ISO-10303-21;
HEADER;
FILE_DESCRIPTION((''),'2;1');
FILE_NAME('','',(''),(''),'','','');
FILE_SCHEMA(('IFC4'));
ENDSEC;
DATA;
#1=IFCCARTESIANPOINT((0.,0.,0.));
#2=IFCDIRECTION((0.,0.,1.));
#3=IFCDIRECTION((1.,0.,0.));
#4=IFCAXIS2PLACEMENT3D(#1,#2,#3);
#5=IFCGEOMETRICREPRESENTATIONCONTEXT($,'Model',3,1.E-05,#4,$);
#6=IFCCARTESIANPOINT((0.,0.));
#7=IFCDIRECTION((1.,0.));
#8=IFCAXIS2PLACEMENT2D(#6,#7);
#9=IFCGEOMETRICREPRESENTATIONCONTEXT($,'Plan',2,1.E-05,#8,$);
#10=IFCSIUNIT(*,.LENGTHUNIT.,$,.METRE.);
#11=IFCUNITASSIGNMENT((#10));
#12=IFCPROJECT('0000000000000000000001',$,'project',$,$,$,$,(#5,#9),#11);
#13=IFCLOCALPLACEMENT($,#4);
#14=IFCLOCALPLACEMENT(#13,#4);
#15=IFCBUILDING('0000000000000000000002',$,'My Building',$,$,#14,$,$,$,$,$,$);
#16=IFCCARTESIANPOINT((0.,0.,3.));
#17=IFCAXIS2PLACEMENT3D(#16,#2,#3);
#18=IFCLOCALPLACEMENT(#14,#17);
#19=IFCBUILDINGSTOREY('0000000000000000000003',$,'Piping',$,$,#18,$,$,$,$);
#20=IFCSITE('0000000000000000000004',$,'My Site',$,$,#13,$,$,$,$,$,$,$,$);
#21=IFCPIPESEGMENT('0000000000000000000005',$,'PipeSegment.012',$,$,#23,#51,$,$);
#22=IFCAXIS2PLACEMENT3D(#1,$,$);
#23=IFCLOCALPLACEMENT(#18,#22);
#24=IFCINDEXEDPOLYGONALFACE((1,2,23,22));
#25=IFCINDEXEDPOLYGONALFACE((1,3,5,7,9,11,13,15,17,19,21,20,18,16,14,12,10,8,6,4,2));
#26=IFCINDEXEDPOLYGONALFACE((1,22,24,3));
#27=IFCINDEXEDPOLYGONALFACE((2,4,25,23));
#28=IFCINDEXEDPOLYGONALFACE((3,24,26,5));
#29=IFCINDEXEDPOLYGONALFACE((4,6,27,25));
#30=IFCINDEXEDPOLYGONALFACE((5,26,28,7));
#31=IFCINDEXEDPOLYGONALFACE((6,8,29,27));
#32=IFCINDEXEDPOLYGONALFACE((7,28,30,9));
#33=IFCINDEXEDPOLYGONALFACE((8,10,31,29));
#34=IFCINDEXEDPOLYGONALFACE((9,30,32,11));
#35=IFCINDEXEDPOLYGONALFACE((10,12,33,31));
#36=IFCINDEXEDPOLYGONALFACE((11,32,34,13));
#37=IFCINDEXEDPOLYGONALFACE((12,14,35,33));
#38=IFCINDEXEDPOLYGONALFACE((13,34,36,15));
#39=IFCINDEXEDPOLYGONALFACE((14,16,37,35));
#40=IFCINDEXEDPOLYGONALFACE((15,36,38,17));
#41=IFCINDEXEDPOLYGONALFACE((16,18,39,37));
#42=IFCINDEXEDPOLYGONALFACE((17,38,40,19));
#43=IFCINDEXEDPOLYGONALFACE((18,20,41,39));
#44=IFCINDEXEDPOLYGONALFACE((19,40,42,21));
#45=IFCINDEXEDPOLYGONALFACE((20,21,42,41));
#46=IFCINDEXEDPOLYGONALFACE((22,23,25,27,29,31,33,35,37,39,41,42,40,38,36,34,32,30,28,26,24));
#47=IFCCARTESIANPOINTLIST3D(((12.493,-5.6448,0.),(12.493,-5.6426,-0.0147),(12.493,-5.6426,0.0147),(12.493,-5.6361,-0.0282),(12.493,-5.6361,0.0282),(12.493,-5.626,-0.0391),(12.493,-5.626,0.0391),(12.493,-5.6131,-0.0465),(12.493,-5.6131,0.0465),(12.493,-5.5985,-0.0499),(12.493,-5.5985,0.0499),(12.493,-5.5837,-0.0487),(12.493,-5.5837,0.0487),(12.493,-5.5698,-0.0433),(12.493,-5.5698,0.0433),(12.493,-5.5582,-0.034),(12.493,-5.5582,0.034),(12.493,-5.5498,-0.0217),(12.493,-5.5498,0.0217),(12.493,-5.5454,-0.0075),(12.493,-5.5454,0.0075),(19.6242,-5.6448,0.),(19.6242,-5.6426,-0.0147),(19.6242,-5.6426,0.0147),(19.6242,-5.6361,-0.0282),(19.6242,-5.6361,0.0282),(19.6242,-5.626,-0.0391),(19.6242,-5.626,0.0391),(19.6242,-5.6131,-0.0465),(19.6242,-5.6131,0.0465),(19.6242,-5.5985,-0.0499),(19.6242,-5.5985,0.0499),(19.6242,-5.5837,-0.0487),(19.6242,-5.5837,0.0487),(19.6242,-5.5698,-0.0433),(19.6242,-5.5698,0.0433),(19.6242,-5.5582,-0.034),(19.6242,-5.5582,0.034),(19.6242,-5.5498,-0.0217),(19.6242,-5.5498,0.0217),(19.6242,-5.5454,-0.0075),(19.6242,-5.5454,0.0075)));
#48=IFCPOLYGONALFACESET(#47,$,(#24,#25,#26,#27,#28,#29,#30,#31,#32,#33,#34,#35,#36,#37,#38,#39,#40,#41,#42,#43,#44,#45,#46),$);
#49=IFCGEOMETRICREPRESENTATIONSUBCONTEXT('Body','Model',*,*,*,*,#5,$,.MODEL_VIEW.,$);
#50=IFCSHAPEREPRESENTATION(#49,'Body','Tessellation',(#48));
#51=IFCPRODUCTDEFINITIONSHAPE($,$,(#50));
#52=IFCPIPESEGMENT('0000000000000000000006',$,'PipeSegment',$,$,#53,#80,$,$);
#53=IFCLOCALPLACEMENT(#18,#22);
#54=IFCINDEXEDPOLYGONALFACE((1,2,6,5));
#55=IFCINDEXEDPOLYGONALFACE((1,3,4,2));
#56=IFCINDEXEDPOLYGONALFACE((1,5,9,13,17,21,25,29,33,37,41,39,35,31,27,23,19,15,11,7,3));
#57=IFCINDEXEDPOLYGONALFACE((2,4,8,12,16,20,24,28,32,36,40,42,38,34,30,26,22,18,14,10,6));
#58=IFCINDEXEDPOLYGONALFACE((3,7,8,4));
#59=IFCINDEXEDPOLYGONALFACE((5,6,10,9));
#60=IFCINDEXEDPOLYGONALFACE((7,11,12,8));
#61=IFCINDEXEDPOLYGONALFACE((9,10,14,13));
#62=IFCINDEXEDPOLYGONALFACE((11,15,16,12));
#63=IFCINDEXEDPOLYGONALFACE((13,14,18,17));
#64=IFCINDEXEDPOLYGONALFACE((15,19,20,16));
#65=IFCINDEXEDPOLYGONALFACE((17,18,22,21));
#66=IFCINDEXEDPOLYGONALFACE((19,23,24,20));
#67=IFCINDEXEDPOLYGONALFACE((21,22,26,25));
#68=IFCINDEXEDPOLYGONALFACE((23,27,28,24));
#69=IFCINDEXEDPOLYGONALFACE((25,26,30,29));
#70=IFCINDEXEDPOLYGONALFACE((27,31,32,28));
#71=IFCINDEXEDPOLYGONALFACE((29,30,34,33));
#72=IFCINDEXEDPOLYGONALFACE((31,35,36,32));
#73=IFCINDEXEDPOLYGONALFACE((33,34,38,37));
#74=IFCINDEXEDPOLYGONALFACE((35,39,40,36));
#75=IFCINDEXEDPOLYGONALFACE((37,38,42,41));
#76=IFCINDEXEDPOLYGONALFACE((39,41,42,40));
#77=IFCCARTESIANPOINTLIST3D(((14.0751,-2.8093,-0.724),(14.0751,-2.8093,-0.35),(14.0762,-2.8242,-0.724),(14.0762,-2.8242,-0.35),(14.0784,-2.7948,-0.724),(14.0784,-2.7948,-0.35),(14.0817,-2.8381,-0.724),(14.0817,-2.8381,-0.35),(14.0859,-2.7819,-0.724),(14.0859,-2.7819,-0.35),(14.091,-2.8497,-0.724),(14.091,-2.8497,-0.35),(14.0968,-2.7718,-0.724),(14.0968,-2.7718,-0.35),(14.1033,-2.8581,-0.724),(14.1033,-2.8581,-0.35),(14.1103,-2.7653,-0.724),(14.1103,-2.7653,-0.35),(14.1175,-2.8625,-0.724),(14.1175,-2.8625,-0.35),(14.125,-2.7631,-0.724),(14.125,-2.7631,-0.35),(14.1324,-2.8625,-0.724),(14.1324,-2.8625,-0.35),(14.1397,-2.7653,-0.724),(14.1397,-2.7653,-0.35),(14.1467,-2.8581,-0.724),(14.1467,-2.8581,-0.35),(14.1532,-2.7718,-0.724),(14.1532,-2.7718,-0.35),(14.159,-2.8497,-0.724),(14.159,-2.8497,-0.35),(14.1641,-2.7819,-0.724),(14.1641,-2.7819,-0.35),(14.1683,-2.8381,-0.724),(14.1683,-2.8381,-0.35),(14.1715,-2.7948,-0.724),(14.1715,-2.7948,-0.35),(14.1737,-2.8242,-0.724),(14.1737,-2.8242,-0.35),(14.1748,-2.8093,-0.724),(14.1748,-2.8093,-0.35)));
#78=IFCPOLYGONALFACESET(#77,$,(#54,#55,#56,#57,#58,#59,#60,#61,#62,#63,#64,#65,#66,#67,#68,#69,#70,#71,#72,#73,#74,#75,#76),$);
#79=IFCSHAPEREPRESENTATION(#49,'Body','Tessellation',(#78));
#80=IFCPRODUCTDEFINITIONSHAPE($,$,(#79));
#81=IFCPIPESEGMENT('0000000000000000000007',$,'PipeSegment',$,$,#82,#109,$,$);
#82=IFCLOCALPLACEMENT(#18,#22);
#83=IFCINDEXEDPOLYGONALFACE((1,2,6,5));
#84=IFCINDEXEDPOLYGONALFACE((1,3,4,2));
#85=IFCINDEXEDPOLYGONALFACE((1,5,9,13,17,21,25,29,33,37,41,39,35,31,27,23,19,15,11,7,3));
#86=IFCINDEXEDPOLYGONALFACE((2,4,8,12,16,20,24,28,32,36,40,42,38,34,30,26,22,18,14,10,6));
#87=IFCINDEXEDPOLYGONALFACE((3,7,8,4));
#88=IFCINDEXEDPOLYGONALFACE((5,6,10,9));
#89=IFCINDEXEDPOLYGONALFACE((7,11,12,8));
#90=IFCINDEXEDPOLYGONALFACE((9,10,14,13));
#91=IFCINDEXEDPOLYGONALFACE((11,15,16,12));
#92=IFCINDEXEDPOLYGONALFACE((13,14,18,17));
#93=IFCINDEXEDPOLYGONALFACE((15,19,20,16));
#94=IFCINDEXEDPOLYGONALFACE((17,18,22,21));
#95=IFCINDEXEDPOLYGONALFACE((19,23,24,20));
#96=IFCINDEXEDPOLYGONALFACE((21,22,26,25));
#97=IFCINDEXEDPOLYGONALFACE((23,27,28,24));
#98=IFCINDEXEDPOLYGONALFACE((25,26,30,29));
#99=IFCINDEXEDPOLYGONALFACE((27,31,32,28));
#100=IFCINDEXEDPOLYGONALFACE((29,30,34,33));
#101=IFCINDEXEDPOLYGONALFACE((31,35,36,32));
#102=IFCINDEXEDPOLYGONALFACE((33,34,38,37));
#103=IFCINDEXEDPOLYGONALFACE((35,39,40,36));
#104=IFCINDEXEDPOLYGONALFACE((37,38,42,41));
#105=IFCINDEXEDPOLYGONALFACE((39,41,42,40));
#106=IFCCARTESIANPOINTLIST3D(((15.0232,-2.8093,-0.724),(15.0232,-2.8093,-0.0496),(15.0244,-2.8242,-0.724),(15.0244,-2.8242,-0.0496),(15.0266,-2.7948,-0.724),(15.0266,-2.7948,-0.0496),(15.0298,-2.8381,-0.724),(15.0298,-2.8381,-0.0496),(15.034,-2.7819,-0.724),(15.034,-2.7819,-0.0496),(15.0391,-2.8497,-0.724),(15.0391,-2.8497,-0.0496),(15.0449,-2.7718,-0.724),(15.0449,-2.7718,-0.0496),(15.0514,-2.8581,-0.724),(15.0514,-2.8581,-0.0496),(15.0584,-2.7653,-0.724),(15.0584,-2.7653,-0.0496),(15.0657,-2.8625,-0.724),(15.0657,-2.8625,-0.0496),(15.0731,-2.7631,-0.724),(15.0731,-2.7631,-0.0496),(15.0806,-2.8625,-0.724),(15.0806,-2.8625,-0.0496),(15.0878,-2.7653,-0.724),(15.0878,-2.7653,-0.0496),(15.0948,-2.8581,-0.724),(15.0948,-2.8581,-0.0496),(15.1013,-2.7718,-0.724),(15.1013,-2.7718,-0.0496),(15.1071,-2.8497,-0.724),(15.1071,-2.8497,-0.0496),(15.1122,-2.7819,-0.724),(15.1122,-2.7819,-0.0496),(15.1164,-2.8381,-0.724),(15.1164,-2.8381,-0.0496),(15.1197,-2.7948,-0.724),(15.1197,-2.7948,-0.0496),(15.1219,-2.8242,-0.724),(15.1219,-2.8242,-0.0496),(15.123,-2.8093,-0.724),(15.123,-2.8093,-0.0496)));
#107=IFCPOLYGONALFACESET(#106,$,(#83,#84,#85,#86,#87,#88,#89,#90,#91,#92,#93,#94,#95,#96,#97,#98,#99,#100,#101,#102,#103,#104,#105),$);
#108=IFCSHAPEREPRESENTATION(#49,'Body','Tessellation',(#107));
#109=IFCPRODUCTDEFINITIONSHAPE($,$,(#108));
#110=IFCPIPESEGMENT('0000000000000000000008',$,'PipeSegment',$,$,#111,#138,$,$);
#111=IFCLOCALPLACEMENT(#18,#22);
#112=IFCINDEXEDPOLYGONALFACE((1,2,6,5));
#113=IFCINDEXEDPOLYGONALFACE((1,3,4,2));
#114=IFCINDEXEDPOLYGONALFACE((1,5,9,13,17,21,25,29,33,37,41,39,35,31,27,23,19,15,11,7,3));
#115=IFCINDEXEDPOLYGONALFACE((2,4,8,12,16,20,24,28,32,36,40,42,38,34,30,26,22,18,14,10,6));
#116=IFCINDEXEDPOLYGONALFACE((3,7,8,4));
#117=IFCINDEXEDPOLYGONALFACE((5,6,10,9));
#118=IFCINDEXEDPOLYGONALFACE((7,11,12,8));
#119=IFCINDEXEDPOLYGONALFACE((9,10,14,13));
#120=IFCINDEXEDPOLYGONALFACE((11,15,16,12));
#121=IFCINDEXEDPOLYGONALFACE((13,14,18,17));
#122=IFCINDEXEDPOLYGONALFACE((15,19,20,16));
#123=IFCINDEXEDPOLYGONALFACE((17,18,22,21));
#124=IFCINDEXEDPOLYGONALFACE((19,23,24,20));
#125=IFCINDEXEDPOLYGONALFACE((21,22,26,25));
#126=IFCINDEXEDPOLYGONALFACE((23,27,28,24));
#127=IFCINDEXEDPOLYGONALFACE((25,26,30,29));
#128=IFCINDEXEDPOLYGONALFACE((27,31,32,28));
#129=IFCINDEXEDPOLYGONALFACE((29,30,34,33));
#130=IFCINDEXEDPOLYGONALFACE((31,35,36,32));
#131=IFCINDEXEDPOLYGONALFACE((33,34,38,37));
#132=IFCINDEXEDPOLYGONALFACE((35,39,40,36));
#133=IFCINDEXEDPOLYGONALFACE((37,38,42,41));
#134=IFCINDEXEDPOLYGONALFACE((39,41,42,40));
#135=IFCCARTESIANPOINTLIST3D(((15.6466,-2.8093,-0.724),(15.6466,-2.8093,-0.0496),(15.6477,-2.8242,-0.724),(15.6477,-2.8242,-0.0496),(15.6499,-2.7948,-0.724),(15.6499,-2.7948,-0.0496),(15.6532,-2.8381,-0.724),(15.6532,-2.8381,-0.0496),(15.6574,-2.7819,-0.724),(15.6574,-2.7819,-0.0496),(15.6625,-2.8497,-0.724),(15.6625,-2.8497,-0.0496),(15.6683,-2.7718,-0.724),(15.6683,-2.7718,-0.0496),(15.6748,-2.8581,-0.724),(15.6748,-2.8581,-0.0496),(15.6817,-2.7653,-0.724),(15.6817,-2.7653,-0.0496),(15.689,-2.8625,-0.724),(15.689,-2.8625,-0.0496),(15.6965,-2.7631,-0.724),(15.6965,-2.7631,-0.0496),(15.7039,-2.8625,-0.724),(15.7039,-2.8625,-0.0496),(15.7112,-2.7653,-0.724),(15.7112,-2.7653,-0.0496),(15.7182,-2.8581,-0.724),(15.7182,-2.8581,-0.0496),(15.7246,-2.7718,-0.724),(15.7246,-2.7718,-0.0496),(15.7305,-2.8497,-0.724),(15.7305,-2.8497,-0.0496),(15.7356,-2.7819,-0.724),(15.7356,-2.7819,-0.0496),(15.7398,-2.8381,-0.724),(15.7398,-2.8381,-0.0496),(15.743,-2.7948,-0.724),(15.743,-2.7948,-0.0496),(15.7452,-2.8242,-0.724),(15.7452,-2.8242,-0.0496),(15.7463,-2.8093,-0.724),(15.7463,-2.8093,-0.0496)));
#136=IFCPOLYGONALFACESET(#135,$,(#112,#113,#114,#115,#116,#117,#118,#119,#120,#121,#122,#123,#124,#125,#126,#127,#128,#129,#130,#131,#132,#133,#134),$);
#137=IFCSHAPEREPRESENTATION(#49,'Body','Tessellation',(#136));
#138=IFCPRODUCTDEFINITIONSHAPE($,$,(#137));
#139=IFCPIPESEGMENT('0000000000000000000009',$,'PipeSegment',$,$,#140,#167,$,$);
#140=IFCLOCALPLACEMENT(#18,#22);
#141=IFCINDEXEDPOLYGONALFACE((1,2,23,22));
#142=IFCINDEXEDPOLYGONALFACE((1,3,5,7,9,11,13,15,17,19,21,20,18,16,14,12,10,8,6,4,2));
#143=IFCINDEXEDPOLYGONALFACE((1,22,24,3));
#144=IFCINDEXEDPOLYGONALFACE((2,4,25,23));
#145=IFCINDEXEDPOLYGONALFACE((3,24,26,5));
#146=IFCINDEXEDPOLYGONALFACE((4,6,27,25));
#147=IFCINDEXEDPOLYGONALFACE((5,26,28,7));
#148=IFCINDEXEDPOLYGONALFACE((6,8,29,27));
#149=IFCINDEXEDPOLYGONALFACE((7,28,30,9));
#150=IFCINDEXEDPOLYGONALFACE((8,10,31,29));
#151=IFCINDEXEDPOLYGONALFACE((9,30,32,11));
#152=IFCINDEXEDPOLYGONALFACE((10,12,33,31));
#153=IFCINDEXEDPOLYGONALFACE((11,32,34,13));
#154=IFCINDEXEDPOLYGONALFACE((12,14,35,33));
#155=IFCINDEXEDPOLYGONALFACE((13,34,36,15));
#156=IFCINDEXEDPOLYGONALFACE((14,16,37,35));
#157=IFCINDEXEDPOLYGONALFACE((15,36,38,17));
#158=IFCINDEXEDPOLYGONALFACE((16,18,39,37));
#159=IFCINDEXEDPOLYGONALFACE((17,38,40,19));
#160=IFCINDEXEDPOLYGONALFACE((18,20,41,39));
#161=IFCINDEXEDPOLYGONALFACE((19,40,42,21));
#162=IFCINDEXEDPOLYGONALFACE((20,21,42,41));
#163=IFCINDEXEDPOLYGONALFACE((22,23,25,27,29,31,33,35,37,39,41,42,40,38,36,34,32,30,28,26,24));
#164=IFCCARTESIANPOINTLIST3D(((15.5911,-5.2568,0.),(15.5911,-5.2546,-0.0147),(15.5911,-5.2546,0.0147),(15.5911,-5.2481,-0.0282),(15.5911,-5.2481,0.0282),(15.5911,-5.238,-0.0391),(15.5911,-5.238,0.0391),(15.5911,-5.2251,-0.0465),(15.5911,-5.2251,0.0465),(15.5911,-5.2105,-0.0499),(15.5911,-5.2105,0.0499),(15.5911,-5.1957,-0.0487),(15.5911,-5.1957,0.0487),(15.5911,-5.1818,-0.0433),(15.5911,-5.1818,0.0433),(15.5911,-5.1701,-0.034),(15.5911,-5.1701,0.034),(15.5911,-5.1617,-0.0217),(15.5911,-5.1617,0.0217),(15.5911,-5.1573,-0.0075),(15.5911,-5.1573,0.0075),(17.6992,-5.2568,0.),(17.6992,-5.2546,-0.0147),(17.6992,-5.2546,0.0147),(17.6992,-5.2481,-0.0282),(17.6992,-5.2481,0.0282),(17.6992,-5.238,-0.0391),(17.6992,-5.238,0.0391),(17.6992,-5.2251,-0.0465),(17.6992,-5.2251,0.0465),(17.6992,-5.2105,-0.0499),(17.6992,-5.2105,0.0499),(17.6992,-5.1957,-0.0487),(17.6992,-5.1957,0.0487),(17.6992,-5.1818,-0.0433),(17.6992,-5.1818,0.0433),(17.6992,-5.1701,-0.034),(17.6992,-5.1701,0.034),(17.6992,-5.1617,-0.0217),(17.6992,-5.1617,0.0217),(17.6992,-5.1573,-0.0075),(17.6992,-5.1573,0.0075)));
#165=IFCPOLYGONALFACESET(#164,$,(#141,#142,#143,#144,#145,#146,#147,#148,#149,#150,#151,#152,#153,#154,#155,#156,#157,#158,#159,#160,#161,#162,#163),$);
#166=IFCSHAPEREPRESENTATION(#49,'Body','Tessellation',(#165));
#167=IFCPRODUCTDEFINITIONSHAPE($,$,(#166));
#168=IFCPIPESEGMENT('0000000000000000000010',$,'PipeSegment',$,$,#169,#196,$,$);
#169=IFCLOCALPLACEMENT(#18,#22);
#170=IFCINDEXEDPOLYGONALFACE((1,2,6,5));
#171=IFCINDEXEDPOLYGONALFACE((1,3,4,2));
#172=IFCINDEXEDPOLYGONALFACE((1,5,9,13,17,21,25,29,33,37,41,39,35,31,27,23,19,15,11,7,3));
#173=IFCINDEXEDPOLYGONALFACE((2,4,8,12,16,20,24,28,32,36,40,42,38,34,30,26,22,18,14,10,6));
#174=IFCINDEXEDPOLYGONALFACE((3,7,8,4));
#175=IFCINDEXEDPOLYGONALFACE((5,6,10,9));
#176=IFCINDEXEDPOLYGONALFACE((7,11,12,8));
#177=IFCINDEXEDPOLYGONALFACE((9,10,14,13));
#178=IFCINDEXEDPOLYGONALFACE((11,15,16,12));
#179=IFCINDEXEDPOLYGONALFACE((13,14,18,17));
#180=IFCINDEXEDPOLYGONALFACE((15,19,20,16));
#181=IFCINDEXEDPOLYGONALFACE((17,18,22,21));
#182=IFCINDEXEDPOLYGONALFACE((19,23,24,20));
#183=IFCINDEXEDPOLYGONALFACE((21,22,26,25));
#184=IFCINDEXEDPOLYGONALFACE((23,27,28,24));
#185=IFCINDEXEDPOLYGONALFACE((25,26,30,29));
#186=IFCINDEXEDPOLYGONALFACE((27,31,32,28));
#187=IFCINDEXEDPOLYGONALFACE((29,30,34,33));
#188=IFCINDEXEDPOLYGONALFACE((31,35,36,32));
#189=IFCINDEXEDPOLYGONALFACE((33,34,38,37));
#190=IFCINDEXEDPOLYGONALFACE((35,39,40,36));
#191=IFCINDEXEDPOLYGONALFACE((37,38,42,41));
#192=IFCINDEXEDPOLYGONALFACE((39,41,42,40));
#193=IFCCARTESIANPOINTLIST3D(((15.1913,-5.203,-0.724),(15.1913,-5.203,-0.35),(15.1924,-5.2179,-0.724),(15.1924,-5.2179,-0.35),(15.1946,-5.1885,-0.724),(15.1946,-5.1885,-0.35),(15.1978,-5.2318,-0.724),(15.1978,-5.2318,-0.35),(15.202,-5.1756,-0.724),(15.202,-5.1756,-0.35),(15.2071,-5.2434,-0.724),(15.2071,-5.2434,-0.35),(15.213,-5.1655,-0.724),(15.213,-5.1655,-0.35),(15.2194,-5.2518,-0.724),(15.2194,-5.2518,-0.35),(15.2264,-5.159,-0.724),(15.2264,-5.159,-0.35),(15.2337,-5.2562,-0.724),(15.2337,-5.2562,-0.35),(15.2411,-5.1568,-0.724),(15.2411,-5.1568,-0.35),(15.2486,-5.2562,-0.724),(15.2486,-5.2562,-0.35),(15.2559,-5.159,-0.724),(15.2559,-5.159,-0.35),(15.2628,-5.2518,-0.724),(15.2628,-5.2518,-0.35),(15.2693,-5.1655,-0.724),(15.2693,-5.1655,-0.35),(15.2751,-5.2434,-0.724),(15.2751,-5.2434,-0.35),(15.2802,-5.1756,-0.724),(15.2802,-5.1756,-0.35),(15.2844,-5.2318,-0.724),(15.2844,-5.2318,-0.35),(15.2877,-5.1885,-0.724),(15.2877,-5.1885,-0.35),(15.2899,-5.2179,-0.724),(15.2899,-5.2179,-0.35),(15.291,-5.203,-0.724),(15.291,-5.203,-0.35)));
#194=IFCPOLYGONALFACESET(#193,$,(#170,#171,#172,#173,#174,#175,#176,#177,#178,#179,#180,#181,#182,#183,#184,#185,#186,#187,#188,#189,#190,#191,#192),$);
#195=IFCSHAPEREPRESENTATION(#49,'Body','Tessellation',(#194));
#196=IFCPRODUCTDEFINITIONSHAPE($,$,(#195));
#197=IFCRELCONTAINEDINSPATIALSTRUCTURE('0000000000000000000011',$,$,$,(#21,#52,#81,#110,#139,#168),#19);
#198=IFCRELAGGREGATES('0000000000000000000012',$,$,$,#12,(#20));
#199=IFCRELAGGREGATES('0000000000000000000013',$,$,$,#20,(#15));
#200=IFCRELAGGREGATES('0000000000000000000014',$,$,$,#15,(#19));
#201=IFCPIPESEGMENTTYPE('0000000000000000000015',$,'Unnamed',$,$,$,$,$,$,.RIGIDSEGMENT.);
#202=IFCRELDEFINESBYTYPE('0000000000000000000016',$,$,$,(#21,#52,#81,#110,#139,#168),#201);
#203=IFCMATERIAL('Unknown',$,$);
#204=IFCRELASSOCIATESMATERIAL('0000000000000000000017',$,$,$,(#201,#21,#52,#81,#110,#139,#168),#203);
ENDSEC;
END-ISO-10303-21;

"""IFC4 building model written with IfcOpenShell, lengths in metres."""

from ifc_helpers import new_model, si_unit, frame, origin_with_axes, origin_2d_with_axis, place, context, subcontext, project, spatial, circle, extrude, material, material_profile, profile_set, profile_usage, type_object, element, save


model = new_model("IFC4")

# Units and contexts
model_context = context("Model", 3, precision=1e-05, world=origin_with_axes())
plan_context = context("Plan", 2, precision=1e-05, world=origin_2d_with_axis())
body_context = subcontext(model_context, "Body", "Model", "MODEL_VIEW")
ifc_project = project(units=[si_unit("LENGTHUNIT", "METRE")], contexts=[model_context, plan_context])

# Site, building, storey
site_placement = place(None, origin_with_axes())
site = spatial("IfcSite", under=ifc_project, at=site_placement, Name="My Site")
building_placement = place(site_placement, origin_with_axes())
building = spatial("IfcBuilding", under=site, at=building_placement, Name="My Building")
storey_placement = place(building_placement, frame((0.0, 0.0, 3.0), z_axis=(0.0, 0.0, 1.0), x_axis=(1.0, 0.0, 0.0)))
storey = spatial("IfcBuildingStorey", under=building, at=storey_placement, Name="Piping")

# Pipe segments
ifc_material = material(Name="Unknown")
ifc_material_profile = material_profile(ifc_material, circle(Radius=0.05))
ifc_profile_set = profile_set([ifc_material_profile])
pipe_segment_type = type_object("IfcPipeSegmentType", Name="Unnamed", PredefinedType="RIGIDSEGMENT", material=ifc_profile_set)
ifc_profile_usage_1 = profile_usage(ifc_profile_set, cardinal=5)
pipe_segment_1_placement = place(storey_placement, frame((19.6242, -5.5948, 0.0), z_axis=(-1.0, 0.0, 0.0), x_axis=(0.0, -1.0, 0.0)))
element("IfcPipeSegment", 1, at=pipe_segment_1_placement, inside=storey, type_object=pipe_segment_type, material=ifc_profile_usage_1, Name="PipeSegment.012", context=body_context, shape_type="SweptSolid", body=[
    extrude(circle(Radius=0.05), origin_with_axes(), (0.0, 0.0, 1.0), 7.1312),
])
ifc_profile_usage_2 = profile_usage(ifc_profile_set, cardinal=5)
pipe_segment_2_placement = place(storey_placement, frame((14.125, -2.8131, -0.35), z_axis=(0.0, 0.0, -1.0), x_axis=(0.0, 1.0, 0.0)))
element("IfcPipeSegment", 2, at=pipe_segment_2_placement, inside=storey, type_object=pipe_segment_type, material=ifc_profile_usage_2, Name="PipeSegment", context=body_context, shape_type="SweptSolid", body=[
    extrude(circle(Radius=0.05), origin_with_axes(), (0.0, 0.0, 1.0), 0.374),
])
ifc_profile_usage_3 = profile_usage(ifc_profile_set, cardinal=5)
pipe_segment_3_placement = place(storey_placement, frame((15.0731, -2.8131, -0.0496), z_axis=(0.0, 0.0, -1.0), x_axis=(0.0, 1.0, 0.0)))
element("IfcPipeSegment", 3, at=pipe_segment_3_placement, inside=storey, type_object=pipe_segment_type, material=ifc_profile_usage_3, Name="PipeSegment", context=body_context, shape_type="SweptSolid", body=[
    extrude(circle(Radius=0.05), origin_with_axes(), (0.0, 0.0, 1.0), 0.6743),
])
ifc_profile_usage_4 = profile_usage(ifc_profile_set, cardinal=5)
pipe_segment_4_placement = place(storey_placement, frame((15.6965, -2.8131, -0.0496), z_axis=(0.0, 0.0, -1.0), x_axis=(0.0, 1.0, 0.0)))
element("IfcPipeSegment", 4, at=pipe_segment_4_placement, inside=storey, type_object=pipe_segment_type, material=ifc_profile_usage_4, Name="PipeSegment", context=body_context, shape_type="SweptSolid", body=[
    extrude(circle(Radius=0.05), origin_with_axes(), (0.0, 0.0, 1.0), 0.6743),
])
ifc_profile_usage_5 = profile_usage(ifc_profile_set, cardinal=5)
pipe_segment_5_placement = place(storey_placement, frame((17.6992, -5.2068, 0.0), z_axis=(-1.0, 0.0, 0.0), x_axis=(0.0, -1.0, 0.0)))
element("IfcPipeSegment", 5, at=pipe_segment_5_placement, inside=storey, type_object=pipe_segment_type, material=ifc_profile_usage_5, Name="PipeSegment", context=body_context, shape_type="SweptSolid", body=[
    extrude(circle(Radius=0.05), origin_with_axes(), (0.0, 0.0, 1.0), 2.1081),
])
ifc_profile_usage_6 = profile_usage(ifc_profile_set, cardinal=5)
pipe_segment_6_placement = place(storey_placement, frame((15.2411, -5.2068, -0.35), z_axis=(0.0, 0.0, -1.0), x_axis=(0.0, 1.0, 0.0)))
element("IfcPipeSegment", 6, at=pipe_segment_6_placement, inside=storey, type_object=pipe_segment_type, material=ifc_profile_usage_6, Name="PipeSegment", context=body_context, shape_type="SweptSolid", body=[
    extrude(circle(Radius=0.05), origin_with_axes(), (0.0, 0.0, 1.0), 0.374),
])

save(model, "model.ifc")
